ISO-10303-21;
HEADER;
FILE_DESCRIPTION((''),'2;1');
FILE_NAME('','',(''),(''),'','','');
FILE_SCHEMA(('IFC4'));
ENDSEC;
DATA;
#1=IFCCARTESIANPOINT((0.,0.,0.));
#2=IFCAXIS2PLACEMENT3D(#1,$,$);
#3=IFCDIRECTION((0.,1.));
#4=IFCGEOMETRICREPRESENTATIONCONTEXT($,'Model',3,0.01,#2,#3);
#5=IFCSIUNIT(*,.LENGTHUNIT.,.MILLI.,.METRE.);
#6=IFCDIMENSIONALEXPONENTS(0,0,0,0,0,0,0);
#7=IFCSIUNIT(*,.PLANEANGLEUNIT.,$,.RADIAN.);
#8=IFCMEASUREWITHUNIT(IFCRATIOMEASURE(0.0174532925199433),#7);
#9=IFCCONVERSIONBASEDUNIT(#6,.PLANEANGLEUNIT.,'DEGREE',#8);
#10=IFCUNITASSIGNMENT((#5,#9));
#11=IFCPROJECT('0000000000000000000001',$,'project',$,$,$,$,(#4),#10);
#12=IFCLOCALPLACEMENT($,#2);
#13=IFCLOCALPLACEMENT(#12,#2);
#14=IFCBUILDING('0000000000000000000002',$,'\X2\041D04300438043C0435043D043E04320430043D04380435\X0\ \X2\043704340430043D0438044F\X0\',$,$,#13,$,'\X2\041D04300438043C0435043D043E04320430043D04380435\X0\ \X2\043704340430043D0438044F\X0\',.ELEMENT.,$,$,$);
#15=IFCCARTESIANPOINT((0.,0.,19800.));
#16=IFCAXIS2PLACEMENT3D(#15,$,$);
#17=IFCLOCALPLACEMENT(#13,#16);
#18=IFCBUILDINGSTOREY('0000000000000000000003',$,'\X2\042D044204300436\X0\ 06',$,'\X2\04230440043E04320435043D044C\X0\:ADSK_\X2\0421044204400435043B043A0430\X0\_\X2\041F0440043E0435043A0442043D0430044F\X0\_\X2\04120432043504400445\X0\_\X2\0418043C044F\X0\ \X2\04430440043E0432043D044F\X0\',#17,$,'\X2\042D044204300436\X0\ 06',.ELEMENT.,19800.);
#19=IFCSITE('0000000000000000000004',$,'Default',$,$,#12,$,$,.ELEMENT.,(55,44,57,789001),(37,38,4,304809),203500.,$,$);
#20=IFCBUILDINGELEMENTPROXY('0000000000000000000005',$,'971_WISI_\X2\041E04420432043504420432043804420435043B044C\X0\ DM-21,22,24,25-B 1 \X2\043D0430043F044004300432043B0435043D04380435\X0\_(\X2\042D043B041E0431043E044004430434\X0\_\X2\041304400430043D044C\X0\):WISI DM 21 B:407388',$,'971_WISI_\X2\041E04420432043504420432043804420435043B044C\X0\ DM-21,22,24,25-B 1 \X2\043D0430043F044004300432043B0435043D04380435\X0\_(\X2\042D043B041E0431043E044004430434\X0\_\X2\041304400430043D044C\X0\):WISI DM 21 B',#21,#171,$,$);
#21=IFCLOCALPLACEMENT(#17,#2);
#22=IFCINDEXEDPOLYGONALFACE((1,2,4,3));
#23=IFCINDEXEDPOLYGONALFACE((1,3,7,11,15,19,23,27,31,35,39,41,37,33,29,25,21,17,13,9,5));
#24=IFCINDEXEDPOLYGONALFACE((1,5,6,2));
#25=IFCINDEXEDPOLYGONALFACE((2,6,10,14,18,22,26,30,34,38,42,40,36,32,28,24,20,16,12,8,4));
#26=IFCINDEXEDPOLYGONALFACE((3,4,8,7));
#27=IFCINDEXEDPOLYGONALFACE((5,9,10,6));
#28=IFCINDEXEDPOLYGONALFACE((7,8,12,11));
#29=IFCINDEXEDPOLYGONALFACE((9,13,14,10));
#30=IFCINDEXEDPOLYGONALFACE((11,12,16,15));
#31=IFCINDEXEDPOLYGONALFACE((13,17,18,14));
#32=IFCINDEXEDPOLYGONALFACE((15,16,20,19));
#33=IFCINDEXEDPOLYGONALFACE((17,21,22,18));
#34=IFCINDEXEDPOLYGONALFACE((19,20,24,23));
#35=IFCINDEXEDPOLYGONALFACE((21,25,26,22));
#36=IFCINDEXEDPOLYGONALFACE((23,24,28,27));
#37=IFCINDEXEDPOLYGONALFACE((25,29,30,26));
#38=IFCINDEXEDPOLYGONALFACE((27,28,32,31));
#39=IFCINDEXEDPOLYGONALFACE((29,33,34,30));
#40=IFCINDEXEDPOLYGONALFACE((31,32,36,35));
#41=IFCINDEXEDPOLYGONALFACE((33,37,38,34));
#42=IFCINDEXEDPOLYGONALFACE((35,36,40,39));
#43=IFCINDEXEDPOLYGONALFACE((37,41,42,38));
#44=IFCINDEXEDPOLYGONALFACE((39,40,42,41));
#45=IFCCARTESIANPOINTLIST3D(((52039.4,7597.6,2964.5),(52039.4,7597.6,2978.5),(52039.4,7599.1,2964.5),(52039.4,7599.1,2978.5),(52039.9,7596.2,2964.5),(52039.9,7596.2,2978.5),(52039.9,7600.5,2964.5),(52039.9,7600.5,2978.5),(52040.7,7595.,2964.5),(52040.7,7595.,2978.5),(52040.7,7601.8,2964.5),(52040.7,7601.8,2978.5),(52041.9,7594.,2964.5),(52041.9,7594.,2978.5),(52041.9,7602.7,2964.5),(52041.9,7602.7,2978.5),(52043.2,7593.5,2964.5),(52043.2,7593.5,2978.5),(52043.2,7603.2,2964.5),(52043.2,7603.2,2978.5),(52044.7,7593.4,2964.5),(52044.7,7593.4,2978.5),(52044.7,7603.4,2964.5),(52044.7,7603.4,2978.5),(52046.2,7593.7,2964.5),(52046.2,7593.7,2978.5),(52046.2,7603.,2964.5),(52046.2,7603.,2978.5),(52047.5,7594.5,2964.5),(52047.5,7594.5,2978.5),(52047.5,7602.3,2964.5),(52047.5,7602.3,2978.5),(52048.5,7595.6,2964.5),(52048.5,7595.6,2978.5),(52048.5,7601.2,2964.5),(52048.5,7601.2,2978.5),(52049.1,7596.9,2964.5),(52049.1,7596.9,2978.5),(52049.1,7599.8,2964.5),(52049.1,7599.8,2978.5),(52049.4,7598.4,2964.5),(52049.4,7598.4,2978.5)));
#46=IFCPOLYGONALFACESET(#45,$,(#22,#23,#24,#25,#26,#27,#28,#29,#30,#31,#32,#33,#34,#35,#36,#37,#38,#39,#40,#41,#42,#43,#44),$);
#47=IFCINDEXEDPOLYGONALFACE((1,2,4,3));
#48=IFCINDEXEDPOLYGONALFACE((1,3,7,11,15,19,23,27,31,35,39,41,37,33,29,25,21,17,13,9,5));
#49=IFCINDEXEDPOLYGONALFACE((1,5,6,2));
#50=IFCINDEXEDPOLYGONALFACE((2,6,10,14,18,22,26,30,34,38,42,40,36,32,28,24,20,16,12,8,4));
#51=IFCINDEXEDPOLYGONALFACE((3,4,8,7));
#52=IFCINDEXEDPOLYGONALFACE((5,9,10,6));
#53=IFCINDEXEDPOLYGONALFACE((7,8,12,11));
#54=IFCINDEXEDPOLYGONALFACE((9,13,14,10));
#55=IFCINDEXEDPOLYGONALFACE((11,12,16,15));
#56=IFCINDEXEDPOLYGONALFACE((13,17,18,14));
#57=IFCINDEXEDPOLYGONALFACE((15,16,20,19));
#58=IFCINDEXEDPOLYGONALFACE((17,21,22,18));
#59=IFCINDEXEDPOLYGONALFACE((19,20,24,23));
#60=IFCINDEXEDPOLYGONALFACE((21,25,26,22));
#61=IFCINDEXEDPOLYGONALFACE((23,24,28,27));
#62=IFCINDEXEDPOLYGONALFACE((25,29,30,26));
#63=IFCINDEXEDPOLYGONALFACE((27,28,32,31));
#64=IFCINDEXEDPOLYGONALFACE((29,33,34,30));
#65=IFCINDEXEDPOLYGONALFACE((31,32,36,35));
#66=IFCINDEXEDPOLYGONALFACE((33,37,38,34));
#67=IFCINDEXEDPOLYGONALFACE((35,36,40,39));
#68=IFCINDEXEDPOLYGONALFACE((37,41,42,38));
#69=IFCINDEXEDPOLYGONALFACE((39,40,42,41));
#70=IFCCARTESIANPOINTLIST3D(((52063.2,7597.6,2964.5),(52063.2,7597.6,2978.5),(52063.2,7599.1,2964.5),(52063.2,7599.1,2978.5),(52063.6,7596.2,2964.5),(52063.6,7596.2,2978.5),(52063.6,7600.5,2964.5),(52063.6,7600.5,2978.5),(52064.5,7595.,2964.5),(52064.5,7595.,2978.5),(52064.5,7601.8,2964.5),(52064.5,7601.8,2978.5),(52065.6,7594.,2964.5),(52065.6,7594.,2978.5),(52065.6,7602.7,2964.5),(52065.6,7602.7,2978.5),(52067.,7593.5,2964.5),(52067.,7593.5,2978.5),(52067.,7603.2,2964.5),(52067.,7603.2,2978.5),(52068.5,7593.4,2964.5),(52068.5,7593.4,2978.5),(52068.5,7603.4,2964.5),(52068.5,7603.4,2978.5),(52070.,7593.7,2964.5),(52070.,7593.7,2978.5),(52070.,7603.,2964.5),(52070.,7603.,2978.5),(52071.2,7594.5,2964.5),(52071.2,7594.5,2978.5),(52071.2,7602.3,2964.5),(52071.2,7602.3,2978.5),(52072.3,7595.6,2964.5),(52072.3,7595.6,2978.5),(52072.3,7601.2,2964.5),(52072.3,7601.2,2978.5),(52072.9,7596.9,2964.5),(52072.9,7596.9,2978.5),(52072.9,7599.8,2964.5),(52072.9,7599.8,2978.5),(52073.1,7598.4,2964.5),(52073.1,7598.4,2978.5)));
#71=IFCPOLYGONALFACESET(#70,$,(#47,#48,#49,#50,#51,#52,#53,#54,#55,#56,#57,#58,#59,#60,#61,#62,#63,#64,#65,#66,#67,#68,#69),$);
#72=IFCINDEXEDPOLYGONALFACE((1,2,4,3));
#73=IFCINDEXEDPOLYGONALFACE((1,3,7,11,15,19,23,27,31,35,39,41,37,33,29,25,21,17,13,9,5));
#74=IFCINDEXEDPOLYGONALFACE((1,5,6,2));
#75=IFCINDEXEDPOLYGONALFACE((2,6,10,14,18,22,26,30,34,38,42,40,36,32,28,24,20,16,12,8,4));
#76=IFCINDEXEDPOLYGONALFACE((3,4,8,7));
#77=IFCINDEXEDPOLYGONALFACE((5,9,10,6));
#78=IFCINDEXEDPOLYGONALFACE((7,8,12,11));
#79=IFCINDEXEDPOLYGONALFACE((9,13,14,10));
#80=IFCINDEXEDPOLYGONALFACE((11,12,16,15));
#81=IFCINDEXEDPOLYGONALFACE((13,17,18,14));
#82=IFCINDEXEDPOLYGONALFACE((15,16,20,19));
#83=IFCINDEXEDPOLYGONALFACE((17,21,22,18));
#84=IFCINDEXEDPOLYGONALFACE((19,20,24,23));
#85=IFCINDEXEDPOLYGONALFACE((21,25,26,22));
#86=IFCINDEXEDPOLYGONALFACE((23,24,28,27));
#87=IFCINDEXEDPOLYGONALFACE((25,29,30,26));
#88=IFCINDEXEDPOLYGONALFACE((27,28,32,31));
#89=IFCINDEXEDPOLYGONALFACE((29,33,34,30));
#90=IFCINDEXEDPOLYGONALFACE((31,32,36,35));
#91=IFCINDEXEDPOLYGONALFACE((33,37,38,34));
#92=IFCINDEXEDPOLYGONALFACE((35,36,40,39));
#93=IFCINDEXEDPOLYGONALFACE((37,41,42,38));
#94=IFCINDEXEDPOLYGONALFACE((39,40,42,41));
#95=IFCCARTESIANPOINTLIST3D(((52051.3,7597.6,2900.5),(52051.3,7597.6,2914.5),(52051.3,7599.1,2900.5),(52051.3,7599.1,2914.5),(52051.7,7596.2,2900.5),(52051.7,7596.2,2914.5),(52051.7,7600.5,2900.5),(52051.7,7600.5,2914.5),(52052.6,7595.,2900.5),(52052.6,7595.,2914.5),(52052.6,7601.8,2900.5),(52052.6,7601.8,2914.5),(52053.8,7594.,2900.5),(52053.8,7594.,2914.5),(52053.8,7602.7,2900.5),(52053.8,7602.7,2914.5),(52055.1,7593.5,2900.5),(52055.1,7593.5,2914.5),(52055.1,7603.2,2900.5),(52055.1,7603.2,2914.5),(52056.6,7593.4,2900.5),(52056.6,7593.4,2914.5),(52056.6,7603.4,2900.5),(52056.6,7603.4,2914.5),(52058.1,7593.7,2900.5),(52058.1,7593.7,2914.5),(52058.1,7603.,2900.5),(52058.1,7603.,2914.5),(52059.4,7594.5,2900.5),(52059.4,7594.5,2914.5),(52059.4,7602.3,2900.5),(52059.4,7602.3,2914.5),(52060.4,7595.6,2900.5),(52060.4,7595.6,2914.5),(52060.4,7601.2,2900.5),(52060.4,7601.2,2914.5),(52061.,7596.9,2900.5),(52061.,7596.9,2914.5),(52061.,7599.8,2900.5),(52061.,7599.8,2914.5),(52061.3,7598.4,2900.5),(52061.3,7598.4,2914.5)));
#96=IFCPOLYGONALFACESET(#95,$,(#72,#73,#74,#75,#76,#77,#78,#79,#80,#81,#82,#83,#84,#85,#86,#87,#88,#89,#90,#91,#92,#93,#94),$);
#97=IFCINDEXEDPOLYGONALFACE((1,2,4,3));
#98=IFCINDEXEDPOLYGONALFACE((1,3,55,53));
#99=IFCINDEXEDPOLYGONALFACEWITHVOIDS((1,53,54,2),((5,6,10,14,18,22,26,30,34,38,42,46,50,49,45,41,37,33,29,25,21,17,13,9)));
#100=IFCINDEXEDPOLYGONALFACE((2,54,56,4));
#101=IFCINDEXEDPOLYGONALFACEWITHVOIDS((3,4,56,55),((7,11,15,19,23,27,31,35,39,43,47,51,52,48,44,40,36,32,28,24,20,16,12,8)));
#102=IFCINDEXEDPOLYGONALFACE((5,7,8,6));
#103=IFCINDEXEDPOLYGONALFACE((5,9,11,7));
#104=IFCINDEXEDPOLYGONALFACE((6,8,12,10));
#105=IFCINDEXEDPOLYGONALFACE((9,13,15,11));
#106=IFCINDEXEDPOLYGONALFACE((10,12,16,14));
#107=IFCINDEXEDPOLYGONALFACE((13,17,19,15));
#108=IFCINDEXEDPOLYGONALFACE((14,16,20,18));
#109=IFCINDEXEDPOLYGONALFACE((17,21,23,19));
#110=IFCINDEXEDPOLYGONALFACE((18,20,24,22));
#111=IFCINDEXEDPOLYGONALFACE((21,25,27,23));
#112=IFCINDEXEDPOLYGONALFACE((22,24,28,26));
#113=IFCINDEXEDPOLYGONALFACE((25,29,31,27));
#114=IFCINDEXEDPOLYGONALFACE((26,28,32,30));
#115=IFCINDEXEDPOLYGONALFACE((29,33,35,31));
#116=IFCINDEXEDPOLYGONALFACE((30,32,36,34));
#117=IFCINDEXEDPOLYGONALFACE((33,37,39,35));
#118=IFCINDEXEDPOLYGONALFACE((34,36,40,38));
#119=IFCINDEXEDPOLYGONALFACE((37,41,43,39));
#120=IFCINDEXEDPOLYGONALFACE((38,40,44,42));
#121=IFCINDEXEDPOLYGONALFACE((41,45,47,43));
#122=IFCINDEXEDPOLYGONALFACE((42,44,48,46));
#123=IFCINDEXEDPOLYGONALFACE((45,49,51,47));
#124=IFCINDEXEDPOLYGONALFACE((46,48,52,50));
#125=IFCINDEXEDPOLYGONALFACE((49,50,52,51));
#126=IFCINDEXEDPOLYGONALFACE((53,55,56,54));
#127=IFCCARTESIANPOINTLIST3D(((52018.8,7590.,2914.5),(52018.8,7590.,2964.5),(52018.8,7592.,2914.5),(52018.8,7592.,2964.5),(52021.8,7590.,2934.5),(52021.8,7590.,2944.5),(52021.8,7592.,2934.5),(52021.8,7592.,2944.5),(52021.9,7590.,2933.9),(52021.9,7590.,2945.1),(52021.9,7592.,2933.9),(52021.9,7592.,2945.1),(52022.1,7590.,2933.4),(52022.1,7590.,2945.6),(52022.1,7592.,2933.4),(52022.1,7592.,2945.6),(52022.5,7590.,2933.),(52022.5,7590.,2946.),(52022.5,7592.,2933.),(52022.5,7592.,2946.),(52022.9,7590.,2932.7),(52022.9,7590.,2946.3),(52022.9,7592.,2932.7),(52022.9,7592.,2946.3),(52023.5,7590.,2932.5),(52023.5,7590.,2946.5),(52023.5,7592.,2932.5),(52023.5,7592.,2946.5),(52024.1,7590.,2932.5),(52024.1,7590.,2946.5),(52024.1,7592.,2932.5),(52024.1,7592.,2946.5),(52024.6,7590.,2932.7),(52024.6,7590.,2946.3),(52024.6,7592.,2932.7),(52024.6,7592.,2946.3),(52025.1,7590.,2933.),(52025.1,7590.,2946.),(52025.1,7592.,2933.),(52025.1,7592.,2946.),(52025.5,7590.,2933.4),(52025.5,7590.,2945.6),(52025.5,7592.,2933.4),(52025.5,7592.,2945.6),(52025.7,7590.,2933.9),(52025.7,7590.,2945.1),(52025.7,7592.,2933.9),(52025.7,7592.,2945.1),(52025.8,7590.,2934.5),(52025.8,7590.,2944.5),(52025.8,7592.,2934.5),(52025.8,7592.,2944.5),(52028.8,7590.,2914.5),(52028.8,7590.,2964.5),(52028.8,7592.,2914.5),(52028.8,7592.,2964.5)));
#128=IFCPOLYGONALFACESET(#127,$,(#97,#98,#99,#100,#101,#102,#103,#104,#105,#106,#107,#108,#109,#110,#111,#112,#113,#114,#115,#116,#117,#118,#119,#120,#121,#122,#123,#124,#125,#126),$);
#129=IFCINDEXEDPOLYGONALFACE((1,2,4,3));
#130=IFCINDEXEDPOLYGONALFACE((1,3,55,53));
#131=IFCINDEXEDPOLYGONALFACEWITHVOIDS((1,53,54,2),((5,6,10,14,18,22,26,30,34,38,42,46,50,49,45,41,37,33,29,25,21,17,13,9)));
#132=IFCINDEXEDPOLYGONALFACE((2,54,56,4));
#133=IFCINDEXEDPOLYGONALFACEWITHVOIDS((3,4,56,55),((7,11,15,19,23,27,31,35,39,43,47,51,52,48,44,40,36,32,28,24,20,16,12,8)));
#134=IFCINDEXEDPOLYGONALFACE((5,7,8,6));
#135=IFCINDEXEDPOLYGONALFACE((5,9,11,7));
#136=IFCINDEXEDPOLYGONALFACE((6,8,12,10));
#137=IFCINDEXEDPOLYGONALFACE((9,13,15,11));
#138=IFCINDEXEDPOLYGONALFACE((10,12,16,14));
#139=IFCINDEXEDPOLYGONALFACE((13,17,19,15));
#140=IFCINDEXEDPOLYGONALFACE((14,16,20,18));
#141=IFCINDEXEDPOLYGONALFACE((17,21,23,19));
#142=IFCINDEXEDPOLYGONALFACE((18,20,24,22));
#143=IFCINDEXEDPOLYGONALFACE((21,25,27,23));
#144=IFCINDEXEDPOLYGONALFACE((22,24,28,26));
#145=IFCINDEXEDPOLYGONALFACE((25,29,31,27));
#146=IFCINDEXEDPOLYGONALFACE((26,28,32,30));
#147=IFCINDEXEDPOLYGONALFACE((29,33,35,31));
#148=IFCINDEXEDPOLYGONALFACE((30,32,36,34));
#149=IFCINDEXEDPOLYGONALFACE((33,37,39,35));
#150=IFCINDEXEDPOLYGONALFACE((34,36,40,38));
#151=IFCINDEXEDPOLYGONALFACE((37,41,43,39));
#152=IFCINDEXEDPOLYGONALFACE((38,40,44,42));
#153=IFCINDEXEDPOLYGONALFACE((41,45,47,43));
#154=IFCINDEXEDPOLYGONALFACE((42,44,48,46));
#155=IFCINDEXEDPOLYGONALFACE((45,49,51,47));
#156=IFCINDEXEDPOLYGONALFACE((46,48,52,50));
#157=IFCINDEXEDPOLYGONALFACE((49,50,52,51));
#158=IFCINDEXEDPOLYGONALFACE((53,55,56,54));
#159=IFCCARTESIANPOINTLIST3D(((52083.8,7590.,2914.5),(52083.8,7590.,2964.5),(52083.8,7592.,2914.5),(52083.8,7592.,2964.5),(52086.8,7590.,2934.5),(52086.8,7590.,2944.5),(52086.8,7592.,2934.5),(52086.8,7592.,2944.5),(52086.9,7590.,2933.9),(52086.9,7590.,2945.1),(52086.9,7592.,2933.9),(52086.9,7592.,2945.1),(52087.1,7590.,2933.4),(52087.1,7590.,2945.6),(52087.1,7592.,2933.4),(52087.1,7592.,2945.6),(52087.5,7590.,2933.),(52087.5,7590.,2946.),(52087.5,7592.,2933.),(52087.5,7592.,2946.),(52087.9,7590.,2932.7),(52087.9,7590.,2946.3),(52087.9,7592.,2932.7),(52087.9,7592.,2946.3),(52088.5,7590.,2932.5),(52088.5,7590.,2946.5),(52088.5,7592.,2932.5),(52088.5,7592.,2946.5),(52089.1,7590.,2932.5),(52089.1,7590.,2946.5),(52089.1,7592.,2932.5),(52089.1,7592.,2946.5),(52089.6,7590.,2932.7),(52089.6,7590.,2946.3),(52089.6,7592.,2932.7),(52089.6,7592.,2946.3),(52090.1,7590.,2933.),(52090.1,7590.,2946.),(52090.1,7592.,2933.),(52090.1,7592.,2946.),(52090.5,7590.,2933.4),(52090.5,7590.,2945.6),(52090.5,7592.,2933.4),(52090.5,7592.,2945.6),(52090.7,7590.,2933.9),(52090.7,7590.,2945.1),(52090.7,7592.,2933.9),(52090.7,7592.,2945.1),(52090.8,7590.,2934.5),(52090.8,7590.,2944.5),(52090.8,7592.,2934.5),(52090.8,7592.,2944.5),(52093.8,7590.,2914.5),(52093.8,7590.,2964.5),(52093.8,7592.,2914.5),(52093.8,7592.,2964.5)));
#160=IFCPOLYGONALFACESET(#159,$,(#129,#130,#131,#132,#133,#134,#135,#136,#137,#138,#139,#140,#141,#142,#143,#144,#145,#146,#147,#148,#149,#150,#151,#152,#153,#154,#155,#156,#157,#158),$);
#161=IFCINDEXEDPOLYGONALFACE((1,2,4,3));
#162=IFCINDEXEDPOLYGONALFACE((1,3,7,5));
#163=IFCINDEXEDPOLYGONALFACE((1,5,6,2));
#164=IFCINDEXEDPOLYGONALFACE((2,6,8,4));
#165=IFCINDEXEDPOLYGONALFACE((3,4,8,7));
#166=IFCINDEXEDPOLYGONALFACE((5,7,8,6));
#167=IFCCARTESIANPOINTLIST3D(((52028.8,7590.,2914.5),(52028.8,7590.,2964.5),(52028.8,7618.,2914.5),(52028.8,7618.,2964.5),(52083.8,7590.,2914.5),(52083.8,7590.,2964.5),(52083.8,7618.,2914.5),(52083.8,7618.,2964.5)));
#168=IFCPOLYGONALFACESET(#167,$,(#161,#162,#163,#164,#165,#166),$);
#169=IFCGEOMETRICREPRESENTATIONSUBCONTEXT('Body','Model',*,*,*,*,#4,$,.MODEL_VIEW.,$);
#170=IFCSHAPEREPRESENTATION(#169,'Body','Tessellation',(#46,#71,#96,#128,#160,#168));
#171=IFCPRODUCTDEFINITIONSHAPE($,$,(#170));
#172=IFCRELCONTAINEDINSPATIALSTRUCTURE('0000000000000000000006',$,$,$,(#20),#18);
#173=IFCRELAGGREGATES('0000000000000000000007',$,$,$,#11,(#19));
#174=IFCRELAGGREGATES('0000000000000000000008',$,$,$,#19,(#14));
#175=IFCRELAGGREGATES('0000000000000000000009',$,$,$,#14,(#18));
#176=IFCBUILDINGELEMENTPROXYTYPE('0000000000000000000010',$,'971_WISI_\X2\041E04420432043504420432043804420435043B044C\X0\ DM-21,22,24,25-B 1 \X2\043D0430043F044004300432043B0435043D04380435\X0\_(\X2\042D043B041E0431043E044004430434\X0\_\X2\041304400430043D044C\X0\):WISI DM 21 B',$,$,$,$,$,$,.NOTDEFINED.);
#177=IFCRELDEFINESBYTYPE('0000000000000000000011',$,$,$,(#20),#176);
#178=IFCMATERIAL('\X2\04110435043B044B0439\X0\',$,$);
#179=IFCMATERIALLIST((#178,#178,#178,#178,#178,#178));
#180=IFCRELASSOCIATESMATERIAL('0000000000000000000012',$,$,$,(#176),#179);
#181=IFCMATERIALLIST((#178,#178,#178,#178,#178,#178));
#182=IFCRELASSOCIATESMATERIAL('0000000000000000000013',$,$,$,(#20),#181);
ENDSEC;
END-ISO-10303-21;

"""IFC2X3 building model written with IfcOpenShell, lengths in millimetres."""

from ifc_helpers import new_model, entity, si_unit, converted_unit, direction, frame, frame_2d, origin, place, context, subcontext, project, spatial, polyline, circle_curve, parameter, trimmed, segment, composite_curve, rectangle, circle, outline, extrude, source, transform, mapped, material, material_list, type_object, type_shapes, element, save


model = new_model("IFC2X3")

# Units and contexts
model_context = context("Model", 3, precision=0.01, world=origin(), true_north=direction((0.0, 1.0)))
body_context = subcontext(model_context, "Body", "Model", "MODEL_VIEW")
ifc_project = project(units=[si_unit("LENGTHUNIT", "METRE", prefix="MILLI"), converted_unit("PLANEANGLEUNIT", "DEGREE", entity("IfcRatioMeasure", 0.0174532925199433), si_unit("PLANEANGLEUNIT", "RADIAN"), dimensions=[0, 0, 0, 0, 0, 0, 0])], contexts=[model_context])

# Site, building, storey
site_placement = place(None, frame((0.0, 0.0, 0.0)))
site = spatial("IfcSite", under=ifc_project, at=site_placement, Name="Default", CompositionType="ELEMENT", RefLatitude=(55, 44, 57, 789001), RefLongitude=(37, 38, 4, 304809), RefElevation=203500.0)
building_placement = place(site_placement, origin())
building = spatial("IfcBuilding", under=site, at=building_placement, Name="Наименование здания", LongName="Наименование здания", CompositionType="ELEMENT")
storey_placement = place(building_placement, frame((0.0, 0.0, 19800.0)))
storey = spatial("IfcBuildingStorey", under=building, at=storey_placement, Name="Этаж 06", ObjectType="Уровень:ADSK_Стрелка_Проектная_Вверх_Имя уровня", LongName="Этаж 06", CompositionType="ELEMENT", Elevation=19800.0)

# Building element proxy
ifc_material_1 = material(Name="Белый")
ifc_material_list_1 = material_list([ifc_material_1, ifc_material_1, ifc_material_1, ifc_material_1, ifc_material_1, ifc_material_1])
ifc_material_list_2 = material_list([ifc_material_1, ifc_material_1, ifc_material_1, ifc_material_1, ifc_material_1, ifc_material_1])
building_element_proxy_type_1 = type_object("IfcBuildingElementProxyType", Name="971_WISI_Ответвитель DM-21,22,24,25-B 1 направление_(ЭлОборуд_Грань):WISI DM 21 B", PredefinedType="NOTDEFINED", material=ifc_material_list_2)
shared_shape_1 = source(origin(), body_context, "Body", "SweptSolid", [
    extrude(circle(Radius=5.0, at=frame_2d((0.0, 0.0), x_axis=(1.0, 0.0))), frame((11.9, 25.0, 8.4), z_axis=(0.0, 1.0, 0.0), x_axis=(-1.0, 0.0, 0.0)), (0.0, 0.0, 1.0), 14.0),
    extrude(circle(Radius=5.0, at=frame_2d((0.0, 0.0), x_axis=(1.0, 0.0))), frame((-11.8, 25.0, 8.4), z_axis=(0.0, 1.0, 0.0), x_axis=(-1.0, 0.0, 0.0)), (0.0, 0.0, 1.0), 14.0),
    extrude(circle(Radius=5.0, at=frame_2d((0.0, 0.0), x_axis=(1.0, 0.0))), frame((0.0, -39.0, 8.4), z_axis=(0.0, 1.0, 0.0), x_axis=(-1.0, 0.0, 0.0)), (0.0, 0.0, 1.0), 14.0),
    extrude(outline(polyline([(-5.0, -25.0), (5.0, -25.0), (5.0, 25.0), (-5.0, 25.0), (-5.0, -25.0)]), holes=[composite_curve([segment(polyline([(2.0, 5.0), (2.0, -5.0)]), True, "CONTINUOUS"), segment(trimmed(circle_curve(frame_2d((0.0, -5.0), x_axis=(-1.0, 0.0)), 2.0), [parameter(0.0)], [parameter(180.0)], True, "PARAMETER"), False, "CONTINUOUS"), segment(polyline([(-2.0, -5.0), (-2.0, 5.0)]), True, "CONTINUOUS"), segment(trimmed(circle_curve(frame_2d((0.0, 5.0), x_axis=(-1.0, 0.0)), 2.0), [parameter(180.0)], [parameter(0.0)], True, "PARAMETER"), False, "CONTINUOUS")], self_intersect=False)]), frame((32.5, 0.0, 0.0), z_axis=(0.0, 0.0, 1.0), x_axis=(-1.0, 0.0, 0.0)), (0.0, 0.0, 1.0), 2.0),
    extrude(outline(polyline([(-5.0, -25.0), (5.0, -25.0), (5.0, 25.0), (-5.0, 25.0), (-5.0, -25.0)]), holes=[composite_curve([segment(polyline([(-2.0, -5.0), (-2.0, 5.0)]), True, "CONTINUOUS"), segment(trimmed(circle_curve(frame_2d((0.0, 5.0), x_axis=(-1.0, 0.0)), 2.0), [parameter(180.0)], [parameter(0.0)], True, "PARAMETER"), False, "CONTINUOUS"), segment(polyline([(2.0, 5.0), (2.0, -5.0)]), True, "CONTINUOUS"), segment(trimmed(circle_curve(frame_2d((0.0, -5.0), x_axis=(-1.0, 0.0)), 2.0), [parameter(0.0)], [parameter(180.0)], True, "PARAMETER"), False, "CONTINUOUS")], self_intersect=False)]), frame((-32.5, 0.0, 0.0), z_axis=(0.0, 0.0, 1.0), x_axis=(-1.0, 0.0, 0.0)), (0.0, 0.0, 1.0), 2.0),
    extrude(rectangle(XDim=55.0, YDim=50.0, at=frame_2d((0.0, 0.0), x_axis=(1.0, 0.0))), frame((0.0, 0.0, 0.0), z_axis=(0.0, 0.0, 1.0), x_axis=(-1.0, 0.0, 0.0)), (0.0, 0.0, 1.0), 28.0),
])
type_shapes(building_element_proxy_type_1, [shared_shape_1])
proxy_1_placement = place(storey_placement, frame((52056.3, 7590.0, 2939.5), z_axis=(0.0, 1.0, 0.0), x_axis=(-1.0, 0.0, 0.0)))
element("IfcBuildingElementProxy", 1, at=proxy_1_placement, inside=storey, type_object=building_element_proxy_type_1, material=ifc_material_list_1, Name="971_WISI_Ответвитель DM-21,22,24,25-B 1 направление_(ЭлОборуд_Грань):WISI DM 21 B:407388", ObjectType="971_WISI_Ответвитель DM-21,22,24,25-B 1 направление_(ЭлОборуд_Грань):WISI DM 21 B", context=body_context, shape_type="MappedRepresentation", body=[
    mapped(shared_shape_1, transform((0.0, 0.0, 0.0), scale=1.0)),
])

save(model, "model.ifc")
